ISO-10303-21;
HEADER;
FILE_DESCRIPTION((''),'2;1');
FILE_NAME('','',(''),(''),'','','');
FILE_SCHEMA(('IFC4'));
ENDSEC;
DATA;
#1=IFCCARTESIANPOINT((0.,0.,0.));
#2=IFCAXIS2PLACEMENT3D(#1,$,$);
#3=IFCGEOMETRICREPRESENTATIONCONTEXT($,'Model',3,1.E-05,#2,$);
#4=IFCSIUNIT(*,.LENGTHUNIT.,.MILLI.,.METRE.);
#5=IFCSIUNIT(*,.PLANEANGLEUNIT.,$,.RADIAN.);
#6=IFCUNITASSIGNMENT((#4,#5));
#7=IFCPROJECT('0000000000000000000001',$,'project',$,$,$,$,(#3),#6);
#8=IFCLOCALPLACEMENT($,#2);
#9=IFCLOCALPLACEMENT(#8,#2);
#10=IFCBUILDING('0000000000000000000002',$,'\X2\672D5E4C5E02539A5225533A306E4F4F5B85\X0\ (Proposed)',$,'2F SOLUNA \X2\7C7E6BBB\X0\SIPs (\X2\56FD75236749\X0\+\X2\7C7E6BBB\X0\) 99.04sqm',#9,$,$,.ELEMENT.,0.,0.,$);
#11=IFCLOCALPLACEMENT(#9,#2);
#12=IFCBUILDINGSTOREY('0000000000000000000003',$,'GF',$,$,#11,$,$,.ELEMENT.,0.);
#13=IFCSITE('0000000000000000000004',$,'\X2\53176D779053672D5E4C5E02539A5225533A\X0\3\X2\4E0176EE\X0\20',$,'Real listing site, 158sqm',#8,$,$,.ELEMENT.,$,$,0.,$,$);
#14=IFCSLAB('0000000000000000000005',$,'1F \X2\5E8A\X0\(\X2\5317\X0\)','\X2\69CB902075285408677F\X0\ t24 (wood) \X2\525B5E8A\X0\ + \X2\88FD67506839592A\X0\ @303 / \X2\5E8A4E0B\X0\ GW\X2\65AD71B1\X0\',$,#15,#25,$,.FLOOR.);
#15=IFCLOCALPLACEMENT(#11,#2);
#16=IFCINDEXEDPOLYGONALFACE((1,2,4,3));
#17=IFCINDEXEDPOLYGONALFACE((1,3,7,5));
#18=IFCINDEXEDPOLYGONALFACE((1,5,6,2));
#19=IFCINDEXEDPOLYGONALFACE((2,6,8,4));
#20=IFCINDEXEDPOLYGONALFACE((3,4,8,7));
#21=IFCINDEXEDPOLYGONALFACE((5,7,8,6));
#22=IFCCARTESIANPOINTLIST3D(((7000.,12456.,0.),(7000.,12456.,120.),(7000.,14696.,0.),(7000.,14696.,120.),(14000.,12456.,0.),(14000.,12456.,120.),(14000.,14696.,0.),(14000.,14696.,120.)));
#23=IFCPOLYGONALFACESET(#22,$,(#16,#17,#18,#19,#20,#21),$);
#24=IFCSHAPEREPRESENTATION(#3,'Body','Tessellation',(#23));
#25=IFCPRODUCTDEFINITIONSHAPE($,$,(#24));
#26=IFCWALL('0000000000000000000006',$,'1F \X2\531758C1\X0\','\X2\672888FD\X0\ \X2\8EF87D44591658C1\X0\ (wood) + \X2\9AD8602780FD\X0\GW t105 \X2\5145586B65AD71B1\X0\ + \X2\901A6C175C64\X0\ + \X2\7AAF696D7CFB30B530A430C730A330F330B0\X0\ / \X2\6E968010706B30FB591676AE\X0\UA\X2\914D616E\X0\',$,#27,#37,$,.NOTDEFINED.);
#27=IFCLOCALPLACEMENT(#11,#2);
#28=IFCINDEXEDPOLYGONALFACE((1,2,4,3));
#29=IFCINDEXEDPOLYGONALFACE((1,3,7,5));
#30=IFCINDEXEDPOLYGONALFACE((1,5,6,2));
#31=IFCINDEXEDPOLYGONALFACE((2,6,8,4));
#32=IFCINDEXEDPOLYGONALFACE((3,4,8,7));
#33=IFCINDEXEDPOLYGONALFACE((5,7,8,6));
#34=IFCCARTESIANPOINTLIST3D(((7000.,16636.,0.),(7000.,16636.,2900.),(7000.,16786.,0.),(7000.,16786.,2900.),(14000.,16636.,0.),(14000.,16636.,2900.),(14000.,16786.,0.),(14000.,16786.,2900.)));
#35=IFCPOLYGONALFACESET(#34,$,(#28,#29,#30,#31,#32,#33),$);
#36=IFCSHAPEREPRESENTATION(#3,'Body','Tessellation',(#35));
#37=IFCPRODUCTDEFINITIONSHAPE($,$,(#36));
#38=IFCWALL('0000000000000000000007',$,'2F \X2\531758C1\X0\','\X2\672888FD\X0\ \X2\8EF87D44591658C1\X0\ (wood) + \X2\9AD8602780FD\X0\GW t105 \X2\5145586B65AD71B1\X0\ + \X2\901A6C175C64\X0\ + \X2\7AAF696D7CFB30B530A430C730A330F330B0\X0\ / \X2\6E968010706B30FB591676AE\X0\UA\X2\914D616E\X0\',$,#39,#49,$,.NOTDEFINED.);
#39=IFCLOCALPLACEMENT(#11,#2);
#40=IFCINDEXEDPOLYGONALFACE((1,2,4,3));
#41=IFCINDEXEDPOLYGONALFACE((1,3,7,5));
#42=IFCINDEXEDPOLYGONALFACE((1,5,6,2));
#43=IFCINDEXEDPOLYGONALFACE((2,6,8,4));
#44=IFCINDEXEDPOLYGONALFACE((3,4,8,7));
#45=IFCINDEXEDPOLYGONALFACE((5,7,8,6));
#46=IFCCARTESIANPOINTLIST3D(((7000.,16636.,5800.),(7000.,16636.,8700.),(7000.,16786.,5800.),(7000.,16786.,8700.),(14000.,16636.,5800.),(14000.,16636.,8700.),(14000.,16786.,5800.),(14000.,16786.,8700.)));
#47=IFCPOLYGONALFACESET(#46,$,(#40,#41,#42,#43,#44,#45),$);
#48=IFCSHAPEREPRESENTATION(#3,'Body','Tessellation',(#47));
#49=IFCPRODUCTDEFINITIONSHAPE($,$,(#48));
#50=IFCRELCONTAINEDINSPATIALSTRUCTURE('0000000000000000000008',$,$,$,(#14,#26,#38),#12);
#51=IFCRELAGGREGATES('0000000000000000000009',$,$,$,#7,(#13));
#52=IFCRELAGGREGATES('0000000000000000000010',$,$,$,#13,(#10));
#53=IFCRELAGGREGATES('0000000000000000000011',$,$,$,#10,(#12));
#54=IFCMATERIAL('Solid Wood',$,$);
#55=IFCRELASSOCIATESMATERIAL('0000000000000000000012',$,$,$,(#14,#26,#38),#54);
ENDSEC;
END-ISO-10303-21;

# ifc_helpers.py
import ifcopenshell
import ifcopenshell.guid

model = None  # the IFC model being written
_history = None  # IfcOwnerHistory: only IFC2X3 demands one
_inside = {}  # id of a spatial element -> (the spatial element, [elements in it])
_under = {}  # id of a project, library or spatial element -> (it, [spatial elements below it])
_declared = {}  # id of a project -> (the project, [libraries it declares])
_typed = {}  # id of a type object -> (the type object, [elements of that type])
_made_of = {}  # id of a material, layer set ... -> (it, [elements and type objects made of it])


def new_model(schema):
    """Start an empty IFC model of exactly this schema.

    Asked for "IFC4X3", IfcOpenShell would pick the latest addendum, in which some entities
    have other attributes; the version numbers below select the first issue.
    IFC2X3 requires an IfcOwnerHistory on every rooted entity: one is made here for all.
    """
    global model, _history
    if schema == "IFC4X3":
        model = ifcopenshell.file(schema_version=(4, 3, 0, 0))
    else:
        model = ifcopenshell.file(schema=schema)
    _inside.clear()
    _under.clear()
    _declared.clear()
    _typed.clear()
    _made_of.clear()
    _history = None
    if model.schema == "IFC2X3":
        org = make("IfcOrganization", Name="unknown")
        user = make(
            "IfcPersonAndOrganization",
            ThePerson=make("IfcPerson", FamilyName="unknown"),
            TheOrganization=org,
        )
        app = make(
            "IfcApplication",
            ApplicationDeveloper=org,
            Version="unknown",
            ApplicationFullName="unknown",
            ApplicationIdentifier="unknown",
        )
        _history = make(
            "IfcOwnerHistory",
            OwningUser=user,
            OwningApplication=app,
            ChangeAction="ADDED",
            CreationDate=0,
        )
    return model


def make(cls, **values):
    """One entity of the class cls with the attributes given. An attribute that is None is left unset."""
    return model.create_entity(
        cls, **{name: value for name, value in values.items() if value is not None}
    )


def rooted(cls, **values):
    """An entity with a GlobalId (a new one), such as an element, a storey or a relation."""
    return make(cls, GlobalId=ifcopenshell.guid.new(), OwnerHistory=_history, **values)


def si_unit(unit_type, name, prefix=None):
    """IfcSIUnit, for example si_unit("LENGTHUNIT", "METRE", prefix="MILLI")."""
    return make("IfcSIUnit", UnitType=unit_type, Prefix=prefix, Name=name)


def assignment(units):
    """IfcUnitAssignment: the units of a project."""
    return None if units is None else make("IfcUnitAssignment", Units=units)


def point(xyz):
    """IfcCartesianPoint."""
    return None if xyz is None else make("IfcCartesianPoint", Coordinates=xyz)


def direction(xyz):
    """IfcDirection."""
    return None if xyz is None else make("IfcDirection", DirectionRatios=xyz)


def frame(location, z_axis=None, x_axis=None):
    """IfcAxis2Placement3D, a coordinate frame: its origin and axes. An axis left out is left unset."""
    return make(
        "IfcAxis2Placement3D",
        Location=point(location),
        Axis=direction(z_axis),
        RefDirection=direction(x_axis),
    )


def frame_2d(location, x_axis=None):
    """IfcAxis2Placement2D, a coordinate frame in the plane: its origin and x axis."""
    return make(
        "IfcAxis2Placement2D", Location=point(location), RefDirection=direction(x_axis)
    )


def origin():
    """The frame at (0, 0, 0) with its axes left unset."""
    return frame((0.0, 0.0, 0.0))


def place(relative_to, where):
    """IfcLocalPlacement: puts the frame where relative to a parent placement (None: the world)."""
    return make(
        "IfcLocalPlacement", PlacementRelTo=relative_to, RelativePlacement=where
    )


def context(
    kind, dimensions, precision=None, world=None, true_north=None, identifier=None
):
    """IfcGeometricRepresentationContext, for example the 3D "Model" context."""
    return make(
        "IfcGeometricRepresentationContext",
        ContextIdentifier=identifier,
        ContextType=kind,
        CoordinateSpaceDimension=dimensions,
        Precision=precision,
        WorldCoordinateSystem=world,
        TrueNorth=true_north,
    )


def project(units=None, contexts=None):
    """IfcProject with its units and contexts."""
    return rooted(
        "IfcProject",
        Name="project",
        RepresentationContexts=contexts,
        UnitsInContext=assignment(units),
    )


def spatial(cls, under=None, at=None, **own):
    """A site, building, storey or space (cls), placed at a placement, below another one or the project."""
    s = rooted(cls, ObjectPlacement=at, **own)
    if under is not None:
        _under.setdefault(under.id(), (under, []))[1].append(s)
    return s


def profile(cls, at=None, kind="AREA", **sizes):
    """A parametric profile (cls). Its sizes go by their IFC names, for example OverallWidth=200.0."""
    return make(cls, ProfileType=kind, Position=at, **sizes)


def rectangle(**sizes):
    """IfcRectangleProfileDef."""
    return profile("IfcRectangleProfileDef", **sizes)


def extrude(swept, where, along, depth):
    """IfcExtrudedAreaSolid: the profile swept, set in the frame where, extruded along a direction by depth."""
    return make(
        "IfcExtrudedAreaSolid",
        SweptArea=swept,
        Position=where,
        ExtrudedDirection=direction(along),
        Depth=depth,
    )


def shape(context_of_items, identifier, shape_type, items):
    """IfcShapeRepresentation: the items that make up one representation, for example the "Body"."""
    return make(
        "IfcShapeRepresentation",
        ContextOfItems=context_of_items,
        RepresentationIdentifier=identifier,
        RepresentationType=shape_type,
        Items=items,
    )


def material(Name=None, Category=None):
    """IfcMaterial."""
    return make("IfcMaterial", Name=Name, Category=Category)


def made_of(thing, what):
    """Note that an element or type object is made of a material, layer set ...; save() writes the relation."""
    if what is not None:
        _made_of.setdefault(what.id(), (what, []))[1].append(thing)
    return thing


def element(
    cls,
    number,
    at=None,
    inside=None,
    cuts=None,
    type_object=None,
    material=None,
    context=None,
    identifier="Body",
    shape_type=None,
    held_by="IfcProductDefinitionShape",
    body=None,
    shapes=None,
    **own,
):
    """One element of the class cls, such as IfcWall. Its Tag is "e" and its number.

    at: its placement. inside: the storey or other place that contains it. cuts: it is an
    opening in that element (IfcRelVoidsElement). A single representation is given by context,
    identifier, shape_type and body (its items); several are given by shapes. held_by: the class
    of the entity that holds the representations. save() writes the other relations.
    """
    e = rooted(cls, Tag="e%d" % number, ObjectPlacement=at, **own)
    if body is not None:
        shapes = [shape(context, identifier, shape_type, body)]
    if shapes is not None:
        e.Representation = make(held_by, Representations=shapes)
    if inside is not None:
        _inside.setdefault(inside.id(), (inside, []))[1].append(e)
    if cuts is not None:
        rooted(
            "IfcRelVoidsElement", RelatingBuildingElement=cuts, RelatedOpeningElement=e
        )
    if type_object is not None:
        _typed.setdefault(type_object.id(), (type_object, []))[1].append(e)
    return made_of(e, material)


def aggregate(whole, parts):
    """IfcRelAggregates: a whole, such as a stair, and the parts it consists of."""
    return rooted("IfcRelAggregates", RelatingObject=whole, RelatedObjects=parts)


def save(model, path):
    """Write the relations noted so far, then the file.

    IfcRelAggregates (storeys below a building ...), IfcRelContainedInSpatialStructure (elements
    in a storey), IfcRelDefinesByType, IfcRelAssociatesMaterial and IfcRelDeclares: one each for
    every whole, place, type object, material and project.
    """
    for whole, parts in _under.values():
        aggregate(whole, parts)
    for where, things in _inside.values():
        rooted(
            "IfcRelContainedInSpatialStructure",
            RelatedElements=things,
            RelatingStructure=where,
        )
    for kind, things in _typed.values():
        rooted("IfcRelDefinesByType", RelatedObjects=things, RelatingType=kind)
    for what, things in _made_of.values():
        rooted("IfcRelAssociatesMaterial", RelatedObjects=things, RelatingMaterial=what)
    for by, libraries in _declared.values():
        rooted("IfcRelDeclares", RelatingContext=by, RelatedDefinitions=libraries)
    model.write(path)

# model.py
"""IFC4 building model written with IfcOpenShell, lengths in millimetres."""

from ifc_helpers import new_model, si_unit, frame, frame_2d, origin, place, context, project, spatial, rectangle, extrude, material, element, save


model = new_model("IFC4")

# Units and contexts
model_context = context("Model", 3, precision=1e-05, world=origin())
ifc_project = project(units=[si_unit("LENGTHUNIT", "METRE", prefix="MILLI"), si_unit("PLANEANGLEUNIT", "RADIAN")], contexts=[model_context])

# Site, building, storey
site_placement = place(None, origin())
site = spatial("IfcSite", under=ifc_project, at=site_placement, Name="北海道札幌市厚別区3丁目20", ObjectType="Real listing site, 158sqm", CompositionType="ELEMENT", RefElevation=0.0)
building_placement = place(site_placement, origin())
building = spatial("IfcBuilding", under=site, at=building_placement, Name="札幌市厚別区の住宅 (Proposed)", ObjectType="2F SOLUNA 籾殻SIPs (国産杉+籾殻) 99.04sqm", CompositionType="ELEMENT", ElevationOfRefHeight=0.0, ElevationOfTerrain=0.0)
storey_placement = place(building_placement, origin())
storey = spatial("IfcBuildingStorey", under=building, at=storey_placement, Name="GF", CompositionType="ELEMENT", Elevation=0.0)

# Slab
ifc_material_1 = material(Name="Solid Wood")
slab_1_placement = place(storey_placement, frame((3500.0, 6228.0, 0.0)))
element("IfcSlab", 1, at=slab_1_placement, inside=storey, material=ifc_material_1, Name="1F 床(北)", Description="構造用合板 t24 (wood) 剛床 + 製材根太 @303 / 床下 GW断熱", PredefinedType="FLOOR", context=model_context, shape_type="SweptSolid", body=[
    extrude(rectangle(XDim=7000.0, YDim=2240.0, at=frame_2d((3500.0, 1120.0))), frame((3500.0, 6228.0, 0.0)), (0.0, 0.0, 1.0), 120.0),
])

# Wall
wall_1_placement = place(storey_placement, frame((3500.0, 8318.0, 0.0)))
element("IfcWall", 2, at=wall_1_placement, inside=storey, material=ifc_material_1, Name="1F 北壁", Description="木製 軸組外壁 (wood) + 高性能GW t105 充填断熱 + 通気層 + 窯業系サイディング / 準耐火・外皮UA配慮", PredefinedType="NOTDEFINED", context=model_context, shape_type="SweptSolid", body=[
    extrude(rectangle(XDim=7000.0, YDim=150.0, at=frame_2d((3500.0, 75.0))), frame((3500.0, 8318.0, 0.0)), (0.0, 0.0, 1.0), 2900.0),
])

# Wall
wall_2_placement = place(storey_placement, frame((3500.0, 8318.0, 2900.0)))
element("IfcWall", 3, at=wall_2_placement, inside=storey, material=ifc_material_1, Name="2F 北壁", Description="木製 軸組外壁 (wood) + 高性能GW t105 充填断熱 + 通気層 + 窯業系サイディング / 準耐火・外皮UA配慮", PredefinedType="NOTDEFINED", context=model_context, shape_type="SweptSolid", body=[
    extrude(rectangle(XDim=7000.0, YDim=150.0, at=frame_2d((3500.0, 75.0))), frame((3500.0, 8318.0, 2900.0)), (0.0, 0.0, 1.0), 2900.0),
])

save(model, "model.ifc")
